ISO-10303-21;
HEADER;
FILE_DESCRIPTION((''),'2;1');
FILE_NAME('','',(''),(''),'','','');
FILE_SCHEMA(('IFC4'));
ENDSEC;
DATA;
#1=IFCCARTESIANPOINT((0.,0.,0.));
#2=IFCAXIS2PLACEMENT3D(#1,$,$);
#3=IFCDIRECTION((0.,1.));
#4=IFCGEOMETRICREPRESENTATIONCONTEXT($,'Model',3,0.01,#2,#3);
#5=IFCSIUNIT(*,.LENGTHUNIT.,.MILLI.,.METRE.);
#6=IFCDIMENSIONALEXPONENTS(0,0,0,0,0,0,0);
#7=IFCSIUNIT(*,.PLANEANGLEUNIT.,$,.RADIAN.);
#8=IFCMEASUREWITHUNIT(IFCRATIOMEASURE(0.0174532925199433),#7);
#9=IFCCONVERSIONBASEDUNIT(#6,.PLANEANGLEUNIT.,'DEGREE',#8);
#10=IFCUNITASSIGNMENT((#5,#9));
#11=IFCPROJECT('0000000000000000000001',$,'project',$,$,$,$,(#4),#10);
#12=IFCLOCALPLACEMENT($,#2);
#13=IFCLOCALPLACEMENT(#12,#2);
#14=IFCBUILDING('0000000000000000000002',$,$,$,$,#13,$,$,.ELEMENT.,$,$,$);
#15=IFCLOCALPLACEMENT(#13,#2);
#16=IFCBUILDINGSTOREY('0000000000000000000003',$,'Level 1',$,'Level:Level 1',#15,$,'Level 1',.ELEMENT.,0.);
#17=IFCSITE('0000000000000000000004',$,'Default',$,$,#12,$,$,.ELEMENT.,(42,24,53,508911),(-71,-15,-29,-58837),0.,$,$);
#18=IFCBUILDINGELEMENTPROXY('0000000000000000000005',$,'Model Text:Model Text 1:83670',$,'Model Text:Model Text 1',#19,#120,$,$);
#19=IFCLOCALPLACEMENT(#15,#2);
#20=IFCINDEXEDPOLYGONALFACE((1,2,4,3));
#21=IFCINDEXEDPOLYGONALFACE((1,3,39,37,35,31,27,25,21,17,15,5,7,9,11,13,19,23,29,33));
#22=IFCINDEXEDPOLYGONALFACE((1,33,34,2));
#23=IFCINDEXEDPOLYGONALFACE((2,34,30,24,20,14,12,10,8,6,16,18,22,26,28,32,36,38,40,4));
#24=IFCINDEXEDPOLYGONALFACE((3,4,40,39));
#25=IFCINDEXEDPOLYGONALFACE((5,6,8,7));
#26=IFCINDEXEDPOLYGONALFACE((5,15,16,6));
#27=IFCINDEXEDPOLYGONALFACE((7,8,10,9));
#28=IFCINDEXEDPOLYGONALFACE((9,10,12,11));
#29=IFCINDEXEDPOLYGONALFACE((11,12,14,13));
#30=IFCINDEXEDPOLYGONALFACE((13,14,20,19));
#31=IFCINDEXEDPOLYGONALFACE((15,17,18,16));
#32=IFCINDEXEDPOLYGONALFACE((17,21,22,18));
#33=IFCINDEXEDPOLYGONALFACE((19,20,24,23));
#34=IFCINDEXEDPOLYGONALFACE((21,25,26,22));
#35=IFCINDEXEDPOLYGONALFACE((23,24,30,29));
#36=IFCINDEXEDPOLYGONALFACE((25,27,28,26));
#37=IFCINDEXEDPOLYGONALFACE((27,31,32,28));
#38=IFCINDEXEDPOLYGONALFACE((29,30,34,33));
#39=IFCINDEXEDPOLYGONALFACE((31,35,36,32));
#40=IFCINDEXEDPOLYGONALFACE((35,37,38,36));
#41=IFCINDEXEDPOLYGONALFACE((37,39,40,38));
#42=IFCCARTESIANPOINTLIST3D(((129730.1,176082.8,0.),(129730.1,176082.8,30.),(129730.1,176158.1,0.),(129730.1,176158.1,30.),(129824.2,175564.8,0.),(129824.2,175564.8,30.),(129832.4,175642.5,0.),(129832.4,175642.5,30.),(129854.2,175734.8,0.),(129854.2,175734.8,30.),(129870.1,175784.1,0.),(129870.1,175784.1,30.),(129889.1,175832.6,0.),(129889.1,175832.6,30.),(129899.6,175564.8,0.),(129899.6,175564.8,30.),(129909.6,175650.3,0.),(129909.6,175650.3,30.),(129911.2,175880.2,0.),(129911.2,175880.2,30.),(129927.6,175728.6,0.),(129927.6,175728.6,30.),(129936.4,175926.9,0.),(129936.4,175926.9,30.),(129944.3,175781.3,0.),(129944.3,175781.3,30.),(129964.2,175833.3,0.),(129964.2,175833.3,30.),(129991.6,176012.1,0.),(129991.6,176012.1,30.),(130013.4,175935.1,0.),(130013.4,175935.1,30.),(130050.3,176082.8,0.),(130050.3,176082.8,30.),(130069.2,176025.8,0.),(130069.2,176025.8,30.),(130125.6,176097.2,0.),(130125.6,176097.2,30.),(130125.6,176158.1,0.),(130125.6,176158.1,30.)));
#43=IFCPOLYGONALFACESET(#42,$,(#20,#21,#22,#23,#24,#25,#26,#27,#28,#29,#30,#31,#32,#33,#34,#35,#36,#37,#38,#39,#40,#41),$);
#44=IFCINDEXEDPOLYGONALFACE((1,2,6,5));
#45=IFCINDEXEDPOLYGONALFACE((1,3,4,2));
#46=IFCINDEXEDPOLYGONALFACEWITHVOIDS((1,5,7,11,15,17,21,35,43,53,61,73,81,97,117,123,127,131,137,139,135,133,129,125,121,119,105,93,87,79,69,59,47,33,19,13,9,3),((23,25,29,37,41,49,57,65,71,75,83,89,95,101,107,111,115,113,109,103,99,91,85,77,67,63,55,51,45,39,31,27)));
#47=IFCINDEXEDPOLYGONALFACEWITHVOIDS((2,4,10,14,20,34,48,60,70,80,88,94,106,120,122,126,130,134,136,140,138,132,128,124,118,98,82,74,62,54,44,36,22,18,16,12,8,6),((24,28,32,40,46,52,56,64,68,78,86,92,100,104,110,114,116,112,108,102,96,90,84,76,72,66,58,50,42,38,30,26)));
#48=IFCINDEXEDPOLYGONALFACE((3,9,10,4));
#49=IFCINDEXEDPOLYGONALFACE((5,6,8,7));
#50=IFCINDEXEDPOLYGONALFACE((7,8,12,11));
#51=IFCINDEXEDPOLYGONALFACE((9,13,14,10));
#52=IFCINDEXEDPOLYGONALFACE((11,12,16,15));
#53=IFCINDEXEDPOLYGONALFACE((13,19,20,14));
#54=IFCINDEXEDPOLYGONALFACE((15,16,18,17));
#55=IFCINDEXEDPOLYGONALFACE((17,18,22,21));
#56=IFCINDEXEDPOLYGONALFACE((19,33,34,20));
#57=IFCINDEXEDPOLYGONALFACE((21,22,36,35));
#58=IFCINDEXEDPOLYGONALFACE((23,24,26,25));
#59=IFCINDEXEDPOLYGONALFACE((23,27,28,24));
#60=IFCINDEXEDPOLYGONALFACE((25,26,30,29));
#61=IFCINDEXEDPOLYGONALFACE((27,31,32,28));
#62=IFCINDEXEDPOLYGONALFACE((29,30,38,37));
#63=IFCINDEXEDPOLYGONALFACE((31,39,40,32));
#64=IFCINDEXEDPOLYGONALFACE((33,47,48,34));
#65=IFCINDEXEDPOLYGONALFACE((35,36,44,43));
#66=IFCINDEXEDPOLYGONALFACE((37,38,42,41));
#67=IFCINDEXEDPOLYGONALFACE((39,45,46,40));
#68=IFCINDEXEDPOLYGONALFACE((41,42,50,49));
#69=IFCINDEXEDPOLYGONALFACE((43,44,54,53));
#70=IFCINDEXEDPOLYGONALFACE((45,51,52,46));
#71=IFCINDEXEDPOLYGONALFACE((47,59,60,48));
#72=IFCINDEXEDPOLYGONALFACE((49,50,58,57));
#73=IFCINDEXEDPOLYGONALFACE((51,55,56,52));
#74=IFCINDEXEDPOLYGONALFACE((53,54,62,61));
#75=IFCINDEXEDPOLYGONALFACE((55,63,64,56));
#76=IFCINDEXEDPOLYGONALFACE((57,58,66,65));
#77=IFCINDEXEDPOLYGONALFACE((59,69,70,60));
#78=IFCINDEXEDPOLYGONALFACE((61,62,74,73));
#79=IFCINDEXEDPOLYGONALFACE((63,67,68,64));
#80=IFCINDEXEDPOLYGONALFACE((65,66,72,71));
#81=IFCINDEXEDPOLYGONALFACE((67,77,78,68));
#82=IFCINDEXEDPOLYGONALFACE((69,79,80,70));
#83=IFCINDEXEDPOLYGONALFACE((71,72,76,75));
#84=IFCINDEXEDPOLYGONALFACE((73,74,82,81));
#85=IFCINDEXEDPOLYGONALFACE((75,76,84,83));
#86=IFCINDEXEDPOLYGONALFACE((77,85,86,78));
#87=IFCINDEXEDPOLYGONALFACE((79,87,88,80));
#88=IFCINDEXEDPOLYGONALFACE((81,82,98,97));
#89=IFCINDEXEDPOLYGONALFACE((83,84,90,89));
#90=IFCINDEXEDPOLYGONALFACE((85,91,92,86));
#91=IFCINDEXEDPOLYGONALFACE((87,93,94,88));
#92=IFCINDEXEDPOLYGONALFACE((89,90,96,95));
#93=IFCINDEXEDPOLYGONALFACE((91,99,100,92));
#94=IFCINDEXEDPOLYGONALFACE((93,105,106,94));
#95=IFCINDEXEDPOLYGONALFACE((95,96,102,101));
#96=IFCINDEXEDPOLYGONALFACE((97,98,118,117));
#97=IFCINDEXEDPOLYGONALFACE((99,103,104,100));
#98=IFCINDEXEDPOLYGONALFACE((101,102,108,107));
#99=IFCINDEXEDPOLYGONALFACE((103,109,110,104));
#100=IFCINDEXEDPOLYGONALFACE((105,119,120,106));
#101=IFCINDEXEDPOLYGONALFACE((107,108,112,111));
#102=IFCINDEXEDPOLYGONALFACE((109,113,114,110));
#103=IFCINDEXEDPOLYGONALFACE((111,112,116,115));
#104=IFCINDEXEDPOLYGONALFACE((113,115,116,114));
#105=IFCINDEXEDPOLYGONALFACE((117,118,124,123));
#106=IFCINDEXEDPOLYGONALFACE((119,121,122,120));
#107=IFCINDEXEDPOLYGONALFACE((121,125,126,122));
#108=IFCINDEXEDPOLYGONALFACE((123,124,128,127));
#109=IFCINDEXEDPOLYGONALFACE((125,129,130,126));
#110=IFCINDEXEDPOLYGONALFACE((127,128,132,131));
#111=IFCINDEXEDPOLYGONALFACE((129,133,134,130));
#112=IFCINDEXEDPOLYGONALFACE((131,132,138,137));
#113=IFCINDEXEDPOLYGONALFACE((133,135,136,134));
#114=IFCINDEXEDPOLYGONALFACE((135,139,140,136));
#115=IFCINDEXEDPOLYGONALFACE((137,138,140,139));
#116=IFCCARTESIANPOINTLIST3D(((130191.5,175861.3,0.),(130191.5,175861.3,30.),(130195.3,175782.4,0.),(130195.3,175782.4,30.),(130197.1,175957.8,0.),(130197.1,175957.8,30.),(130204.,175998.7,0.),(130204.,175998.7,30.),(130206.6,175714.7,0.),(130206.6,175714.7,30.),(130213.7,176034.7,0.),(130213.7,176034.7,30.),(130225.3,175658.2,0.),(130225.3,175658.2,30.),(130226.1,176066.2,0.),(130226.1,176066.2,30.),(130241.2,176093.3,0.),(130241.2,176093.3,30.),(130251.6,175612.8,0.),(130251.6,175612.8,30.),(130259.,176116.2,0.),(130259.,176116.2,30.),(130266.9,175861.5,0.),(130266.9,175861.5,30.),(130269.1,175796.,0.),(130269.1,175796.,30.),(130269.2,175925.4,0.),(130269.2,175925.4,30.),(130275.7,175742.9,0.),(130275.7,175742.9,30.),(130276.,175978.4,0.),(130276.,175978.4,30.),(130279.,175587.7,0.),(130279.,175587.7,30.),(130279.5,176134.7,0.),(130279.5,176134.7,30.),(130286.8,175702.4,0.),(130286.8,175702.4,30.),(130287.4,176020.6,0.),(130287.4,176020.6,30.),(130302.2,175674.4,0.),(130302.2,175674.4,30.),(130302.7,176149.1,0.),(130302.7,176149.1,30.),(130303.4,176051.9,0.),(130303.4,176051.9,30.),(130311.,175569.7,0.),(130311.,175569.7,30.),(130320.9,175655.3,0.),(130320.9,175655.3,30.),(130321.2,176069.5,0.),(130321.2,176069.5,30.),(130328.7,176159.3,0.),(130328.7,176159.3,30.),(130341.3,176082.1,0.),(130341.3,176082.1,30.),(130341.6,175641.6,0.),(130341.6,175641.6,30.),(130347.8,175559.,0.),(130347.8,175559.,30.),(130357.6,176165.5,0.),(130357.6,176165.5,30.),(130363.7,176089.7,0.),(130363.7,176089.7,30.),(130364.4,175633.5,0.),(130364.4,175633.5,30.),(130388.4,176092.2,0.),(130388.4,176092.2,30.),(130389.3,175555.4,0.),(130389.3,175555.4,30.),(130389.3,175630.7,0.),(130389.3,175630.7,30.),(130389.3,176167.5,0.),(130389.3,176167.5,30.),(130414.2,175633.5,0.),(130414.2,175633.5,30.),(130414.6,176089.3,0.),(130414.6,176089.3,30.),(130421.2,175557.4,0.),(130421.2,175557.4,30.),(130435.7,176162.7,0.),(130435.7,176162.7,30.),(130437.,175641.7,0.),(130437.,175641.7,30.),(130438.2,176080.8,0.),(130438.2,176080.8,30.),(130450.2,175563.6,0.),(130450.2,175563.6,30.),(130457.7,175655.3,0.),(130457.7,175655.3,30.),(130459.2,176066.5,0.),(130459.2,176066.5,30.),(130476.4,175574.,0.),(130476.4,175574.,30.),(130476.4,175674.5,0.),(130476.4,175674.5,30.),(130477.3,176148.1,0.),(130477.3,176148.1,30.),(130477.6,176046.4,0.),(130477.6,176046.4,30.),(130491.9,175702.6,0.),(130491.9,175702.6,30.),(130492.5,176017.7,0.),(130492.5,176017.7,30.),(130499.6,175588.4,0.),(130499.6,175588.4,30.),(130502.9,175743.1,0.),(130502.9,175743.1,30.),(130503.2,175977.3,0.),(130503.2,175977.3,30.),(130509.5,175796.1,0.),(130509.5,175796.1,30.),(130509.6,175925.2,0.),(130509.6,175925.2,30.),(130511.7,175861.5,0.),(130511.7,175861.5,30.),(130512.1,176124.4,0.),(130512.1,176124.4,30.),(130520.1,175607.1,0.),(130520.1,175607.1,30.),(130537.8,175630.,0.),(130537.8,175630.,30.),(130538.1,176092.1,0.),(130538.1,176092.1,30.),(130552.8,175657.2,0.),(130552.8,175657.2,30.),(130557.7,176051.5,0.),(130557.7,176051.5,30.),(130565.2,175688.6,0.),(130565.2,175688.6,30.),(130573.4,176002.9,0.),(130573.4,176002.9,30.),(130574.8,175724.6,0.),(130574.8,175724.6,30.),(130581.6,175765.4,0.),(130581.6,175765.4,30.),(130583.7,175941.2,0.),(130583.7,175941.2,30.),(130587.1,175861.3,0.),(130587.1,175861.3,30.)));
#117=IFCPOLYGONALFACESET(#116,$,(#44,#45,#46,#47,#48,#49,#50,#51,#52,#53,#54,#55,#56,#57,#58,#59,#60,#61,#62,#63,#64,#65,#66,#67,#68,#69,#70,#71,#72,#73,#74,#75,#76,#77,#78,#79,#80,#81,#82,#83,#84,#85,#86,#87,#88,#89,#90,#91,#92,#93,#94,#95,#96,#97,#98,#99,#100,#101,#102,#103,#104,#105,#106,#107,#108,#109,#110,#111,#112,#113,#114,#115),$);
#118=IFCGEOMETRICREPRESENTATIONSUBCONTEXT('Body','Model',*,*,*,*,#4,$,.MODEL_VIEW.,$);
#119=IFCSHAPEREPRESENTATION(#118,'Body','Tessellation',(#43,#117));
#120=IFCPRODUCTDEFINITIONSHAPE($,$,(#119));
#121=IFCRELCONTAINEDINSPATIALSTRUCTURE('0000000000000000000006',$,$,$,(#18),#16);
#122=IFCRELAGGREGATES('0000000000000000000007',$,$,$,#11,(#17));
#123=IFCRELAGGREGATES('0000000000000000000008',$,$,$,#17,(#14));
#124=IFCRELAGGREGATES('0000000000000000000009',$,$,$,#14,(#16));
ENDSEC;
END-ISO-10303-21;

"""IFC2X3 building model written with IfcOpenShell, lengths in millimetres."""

from ifc_helpers import new_model, entity, si_unit, converted_unit, direction, frame, origin, place, context, subcontext, project, spatial, polyline, outline, extrude, element, save


model = new_model("IFC2X3")

# Units and contexts
model_context = context("Model", 3, precision=0.01, world=origin(), true_north=direction((0.0, 1.0)))
body_context = subcontext(model_context, "Body", "Model", "MODEL_VIEW")
ifc_project = project(units=[si_unit("LENGTHUNIT", "METRE", prefix="MILLI"), converted_unit("PLANEANGLEUNIT", "DEGREE", entity("IfcRatioMeasure", 0.0174532925199433), si_unit("PLANEANGLEUNIT", "RADIAN"), dimensions=[0, 0, 0, 0, 0, 0, 0])], contexts=[model_context])

# Site, building, storey
site_placement = place(None, origin())
site = spatial("IfcSite", under=ifc_project, at=site_placement, Name="Default", CompositionType="ELEMENT", RefLatitude=(42, 24, 53, 508911), RefLongitude=(-71, -15, -29, -58837), RefElevation=0.0)
building_placement = place(site_placement, origin())
building = spatial("IfcBuilding", under=site, at=building_placement, CompositionType="ELEMENT")
storey_placement = place(building_placement, origin())
storey = spatial("IfcBuildingStorey", under=building, at=storey_placement, Name="Level 1", ObjectType="Level:Level 1", LongName="Level 1", CompositionType="ELEMENT", Elevation=0.0)

# Building element proxy
proxy_1_placement = place(storey_placement, origin())
element("IfcBuildingElementProxy", 1, at=proxy_1_placement, inside=storey, Name="Model Text:Model Text 1:83670", ObjectType="Model Text:Model Text 1", context=body_context, shape_type="SweptSolid", body=[
    extrude(outline(polyline([(-199.9, -209.0), (-199.9, -284.3), (195.7, -284.3), (195.7, -223.4), (139.3, -152.0), (83.5, -61.3), (34.2, 40.5), (14.4, 92.5), (-2.4, 145.2), (-20.3, 223.5), (-30.3, 309.0), (-105.7, 309.0), (-97.5, 231.3), (-75.7, 139.0), (-59.9, 89.7), (-40.9, 41.2), (-18.8, -6.4), (6.4, -53.1), (61.7, -138.3), (120.3, -209.0), (-199.9, -209.0)])), frame((129929.9, 175873.8, 0.0), z_axis=(0.0, 0.0, -1.0), x_axis=(1.0, 0.0, 0.0)), (0.0, 0.0, -1.0), 30.0),
    extrude(outline(polyline([(-10.6, -198.7), (68.3, -198.7), (136.5, -190.7), (193.9, -174.7), (240.5, -150.6), (266.9, -124.4), (286.3, -93.2), (298.8, -57.0), (304.3, -15.7), (303.8, 16.2), (299.0, 45.5), (289.9, 72.1), (276.6, 96.0), (258.9, 117.3), (236.9, 136.2), (210.4, 152.5), (179.6, 166.3), (144.1, 177.6), (103.7, 186.3), (8.2, 196.4), (-71.8, 196.7), (-134.0, 189.4), (-183.3, 176.1), (-224.7, 158.4), (-258.2, 133.9), (-283.5, 100.3), (-300.1, 59.5), (-307.1, 13.4), (-306.6, -18.4), (-301.8, -47.5), (-292.8, -74.0), (-279.6, -97.9), (-262.0, -119.2), (-240.0, -138.1), (-213.6, -154.5), (-182.8, -168.4), (-147.3, -179.8), (-106.7, -188.6), (-10.6, -198.7)]), holes=[polyline([(-7.2, -123.5), (-71.0, -118.2), (-123.6, -108.8), (-165.2, -95.4), (-195.7, -78.0), (-212.4, -59.4), (-224.1, -38.7), (-230.6, -15.9), (-231.9, 8.9), (-227.8, 35.0), (-218.1, 58.1), (-202.8, 78.4), (-182.0, 95.8), (-152.6, 109.4), (-111.7, 118.1), (-59.4, 122.0), (4.4, 121.1), (69.6, 115.8), (122.2, 106.7), (162.2, 93.7), (189.5, 77.0), (207.7, 57.4), (220.4, 36.0), (227.5, 12.8), (229.1, -12.1), (225.2, -36.8), (215.9, -59.2), (201.3, -79.3), (181.4, -97.1), (152.6, -111.2), (111.6, -120.3), (58.3, -124.4), (-7.2, -123.5)])]), frame((130390.6, 175860.1, 0.0), z_axis=(0.0, 0.0, 1.0), x_axis=(0.047515, -0.998871, 0.0)), (0.0, 0.0, 1.0), 30.0),
])

save(model, "model.ifc")
